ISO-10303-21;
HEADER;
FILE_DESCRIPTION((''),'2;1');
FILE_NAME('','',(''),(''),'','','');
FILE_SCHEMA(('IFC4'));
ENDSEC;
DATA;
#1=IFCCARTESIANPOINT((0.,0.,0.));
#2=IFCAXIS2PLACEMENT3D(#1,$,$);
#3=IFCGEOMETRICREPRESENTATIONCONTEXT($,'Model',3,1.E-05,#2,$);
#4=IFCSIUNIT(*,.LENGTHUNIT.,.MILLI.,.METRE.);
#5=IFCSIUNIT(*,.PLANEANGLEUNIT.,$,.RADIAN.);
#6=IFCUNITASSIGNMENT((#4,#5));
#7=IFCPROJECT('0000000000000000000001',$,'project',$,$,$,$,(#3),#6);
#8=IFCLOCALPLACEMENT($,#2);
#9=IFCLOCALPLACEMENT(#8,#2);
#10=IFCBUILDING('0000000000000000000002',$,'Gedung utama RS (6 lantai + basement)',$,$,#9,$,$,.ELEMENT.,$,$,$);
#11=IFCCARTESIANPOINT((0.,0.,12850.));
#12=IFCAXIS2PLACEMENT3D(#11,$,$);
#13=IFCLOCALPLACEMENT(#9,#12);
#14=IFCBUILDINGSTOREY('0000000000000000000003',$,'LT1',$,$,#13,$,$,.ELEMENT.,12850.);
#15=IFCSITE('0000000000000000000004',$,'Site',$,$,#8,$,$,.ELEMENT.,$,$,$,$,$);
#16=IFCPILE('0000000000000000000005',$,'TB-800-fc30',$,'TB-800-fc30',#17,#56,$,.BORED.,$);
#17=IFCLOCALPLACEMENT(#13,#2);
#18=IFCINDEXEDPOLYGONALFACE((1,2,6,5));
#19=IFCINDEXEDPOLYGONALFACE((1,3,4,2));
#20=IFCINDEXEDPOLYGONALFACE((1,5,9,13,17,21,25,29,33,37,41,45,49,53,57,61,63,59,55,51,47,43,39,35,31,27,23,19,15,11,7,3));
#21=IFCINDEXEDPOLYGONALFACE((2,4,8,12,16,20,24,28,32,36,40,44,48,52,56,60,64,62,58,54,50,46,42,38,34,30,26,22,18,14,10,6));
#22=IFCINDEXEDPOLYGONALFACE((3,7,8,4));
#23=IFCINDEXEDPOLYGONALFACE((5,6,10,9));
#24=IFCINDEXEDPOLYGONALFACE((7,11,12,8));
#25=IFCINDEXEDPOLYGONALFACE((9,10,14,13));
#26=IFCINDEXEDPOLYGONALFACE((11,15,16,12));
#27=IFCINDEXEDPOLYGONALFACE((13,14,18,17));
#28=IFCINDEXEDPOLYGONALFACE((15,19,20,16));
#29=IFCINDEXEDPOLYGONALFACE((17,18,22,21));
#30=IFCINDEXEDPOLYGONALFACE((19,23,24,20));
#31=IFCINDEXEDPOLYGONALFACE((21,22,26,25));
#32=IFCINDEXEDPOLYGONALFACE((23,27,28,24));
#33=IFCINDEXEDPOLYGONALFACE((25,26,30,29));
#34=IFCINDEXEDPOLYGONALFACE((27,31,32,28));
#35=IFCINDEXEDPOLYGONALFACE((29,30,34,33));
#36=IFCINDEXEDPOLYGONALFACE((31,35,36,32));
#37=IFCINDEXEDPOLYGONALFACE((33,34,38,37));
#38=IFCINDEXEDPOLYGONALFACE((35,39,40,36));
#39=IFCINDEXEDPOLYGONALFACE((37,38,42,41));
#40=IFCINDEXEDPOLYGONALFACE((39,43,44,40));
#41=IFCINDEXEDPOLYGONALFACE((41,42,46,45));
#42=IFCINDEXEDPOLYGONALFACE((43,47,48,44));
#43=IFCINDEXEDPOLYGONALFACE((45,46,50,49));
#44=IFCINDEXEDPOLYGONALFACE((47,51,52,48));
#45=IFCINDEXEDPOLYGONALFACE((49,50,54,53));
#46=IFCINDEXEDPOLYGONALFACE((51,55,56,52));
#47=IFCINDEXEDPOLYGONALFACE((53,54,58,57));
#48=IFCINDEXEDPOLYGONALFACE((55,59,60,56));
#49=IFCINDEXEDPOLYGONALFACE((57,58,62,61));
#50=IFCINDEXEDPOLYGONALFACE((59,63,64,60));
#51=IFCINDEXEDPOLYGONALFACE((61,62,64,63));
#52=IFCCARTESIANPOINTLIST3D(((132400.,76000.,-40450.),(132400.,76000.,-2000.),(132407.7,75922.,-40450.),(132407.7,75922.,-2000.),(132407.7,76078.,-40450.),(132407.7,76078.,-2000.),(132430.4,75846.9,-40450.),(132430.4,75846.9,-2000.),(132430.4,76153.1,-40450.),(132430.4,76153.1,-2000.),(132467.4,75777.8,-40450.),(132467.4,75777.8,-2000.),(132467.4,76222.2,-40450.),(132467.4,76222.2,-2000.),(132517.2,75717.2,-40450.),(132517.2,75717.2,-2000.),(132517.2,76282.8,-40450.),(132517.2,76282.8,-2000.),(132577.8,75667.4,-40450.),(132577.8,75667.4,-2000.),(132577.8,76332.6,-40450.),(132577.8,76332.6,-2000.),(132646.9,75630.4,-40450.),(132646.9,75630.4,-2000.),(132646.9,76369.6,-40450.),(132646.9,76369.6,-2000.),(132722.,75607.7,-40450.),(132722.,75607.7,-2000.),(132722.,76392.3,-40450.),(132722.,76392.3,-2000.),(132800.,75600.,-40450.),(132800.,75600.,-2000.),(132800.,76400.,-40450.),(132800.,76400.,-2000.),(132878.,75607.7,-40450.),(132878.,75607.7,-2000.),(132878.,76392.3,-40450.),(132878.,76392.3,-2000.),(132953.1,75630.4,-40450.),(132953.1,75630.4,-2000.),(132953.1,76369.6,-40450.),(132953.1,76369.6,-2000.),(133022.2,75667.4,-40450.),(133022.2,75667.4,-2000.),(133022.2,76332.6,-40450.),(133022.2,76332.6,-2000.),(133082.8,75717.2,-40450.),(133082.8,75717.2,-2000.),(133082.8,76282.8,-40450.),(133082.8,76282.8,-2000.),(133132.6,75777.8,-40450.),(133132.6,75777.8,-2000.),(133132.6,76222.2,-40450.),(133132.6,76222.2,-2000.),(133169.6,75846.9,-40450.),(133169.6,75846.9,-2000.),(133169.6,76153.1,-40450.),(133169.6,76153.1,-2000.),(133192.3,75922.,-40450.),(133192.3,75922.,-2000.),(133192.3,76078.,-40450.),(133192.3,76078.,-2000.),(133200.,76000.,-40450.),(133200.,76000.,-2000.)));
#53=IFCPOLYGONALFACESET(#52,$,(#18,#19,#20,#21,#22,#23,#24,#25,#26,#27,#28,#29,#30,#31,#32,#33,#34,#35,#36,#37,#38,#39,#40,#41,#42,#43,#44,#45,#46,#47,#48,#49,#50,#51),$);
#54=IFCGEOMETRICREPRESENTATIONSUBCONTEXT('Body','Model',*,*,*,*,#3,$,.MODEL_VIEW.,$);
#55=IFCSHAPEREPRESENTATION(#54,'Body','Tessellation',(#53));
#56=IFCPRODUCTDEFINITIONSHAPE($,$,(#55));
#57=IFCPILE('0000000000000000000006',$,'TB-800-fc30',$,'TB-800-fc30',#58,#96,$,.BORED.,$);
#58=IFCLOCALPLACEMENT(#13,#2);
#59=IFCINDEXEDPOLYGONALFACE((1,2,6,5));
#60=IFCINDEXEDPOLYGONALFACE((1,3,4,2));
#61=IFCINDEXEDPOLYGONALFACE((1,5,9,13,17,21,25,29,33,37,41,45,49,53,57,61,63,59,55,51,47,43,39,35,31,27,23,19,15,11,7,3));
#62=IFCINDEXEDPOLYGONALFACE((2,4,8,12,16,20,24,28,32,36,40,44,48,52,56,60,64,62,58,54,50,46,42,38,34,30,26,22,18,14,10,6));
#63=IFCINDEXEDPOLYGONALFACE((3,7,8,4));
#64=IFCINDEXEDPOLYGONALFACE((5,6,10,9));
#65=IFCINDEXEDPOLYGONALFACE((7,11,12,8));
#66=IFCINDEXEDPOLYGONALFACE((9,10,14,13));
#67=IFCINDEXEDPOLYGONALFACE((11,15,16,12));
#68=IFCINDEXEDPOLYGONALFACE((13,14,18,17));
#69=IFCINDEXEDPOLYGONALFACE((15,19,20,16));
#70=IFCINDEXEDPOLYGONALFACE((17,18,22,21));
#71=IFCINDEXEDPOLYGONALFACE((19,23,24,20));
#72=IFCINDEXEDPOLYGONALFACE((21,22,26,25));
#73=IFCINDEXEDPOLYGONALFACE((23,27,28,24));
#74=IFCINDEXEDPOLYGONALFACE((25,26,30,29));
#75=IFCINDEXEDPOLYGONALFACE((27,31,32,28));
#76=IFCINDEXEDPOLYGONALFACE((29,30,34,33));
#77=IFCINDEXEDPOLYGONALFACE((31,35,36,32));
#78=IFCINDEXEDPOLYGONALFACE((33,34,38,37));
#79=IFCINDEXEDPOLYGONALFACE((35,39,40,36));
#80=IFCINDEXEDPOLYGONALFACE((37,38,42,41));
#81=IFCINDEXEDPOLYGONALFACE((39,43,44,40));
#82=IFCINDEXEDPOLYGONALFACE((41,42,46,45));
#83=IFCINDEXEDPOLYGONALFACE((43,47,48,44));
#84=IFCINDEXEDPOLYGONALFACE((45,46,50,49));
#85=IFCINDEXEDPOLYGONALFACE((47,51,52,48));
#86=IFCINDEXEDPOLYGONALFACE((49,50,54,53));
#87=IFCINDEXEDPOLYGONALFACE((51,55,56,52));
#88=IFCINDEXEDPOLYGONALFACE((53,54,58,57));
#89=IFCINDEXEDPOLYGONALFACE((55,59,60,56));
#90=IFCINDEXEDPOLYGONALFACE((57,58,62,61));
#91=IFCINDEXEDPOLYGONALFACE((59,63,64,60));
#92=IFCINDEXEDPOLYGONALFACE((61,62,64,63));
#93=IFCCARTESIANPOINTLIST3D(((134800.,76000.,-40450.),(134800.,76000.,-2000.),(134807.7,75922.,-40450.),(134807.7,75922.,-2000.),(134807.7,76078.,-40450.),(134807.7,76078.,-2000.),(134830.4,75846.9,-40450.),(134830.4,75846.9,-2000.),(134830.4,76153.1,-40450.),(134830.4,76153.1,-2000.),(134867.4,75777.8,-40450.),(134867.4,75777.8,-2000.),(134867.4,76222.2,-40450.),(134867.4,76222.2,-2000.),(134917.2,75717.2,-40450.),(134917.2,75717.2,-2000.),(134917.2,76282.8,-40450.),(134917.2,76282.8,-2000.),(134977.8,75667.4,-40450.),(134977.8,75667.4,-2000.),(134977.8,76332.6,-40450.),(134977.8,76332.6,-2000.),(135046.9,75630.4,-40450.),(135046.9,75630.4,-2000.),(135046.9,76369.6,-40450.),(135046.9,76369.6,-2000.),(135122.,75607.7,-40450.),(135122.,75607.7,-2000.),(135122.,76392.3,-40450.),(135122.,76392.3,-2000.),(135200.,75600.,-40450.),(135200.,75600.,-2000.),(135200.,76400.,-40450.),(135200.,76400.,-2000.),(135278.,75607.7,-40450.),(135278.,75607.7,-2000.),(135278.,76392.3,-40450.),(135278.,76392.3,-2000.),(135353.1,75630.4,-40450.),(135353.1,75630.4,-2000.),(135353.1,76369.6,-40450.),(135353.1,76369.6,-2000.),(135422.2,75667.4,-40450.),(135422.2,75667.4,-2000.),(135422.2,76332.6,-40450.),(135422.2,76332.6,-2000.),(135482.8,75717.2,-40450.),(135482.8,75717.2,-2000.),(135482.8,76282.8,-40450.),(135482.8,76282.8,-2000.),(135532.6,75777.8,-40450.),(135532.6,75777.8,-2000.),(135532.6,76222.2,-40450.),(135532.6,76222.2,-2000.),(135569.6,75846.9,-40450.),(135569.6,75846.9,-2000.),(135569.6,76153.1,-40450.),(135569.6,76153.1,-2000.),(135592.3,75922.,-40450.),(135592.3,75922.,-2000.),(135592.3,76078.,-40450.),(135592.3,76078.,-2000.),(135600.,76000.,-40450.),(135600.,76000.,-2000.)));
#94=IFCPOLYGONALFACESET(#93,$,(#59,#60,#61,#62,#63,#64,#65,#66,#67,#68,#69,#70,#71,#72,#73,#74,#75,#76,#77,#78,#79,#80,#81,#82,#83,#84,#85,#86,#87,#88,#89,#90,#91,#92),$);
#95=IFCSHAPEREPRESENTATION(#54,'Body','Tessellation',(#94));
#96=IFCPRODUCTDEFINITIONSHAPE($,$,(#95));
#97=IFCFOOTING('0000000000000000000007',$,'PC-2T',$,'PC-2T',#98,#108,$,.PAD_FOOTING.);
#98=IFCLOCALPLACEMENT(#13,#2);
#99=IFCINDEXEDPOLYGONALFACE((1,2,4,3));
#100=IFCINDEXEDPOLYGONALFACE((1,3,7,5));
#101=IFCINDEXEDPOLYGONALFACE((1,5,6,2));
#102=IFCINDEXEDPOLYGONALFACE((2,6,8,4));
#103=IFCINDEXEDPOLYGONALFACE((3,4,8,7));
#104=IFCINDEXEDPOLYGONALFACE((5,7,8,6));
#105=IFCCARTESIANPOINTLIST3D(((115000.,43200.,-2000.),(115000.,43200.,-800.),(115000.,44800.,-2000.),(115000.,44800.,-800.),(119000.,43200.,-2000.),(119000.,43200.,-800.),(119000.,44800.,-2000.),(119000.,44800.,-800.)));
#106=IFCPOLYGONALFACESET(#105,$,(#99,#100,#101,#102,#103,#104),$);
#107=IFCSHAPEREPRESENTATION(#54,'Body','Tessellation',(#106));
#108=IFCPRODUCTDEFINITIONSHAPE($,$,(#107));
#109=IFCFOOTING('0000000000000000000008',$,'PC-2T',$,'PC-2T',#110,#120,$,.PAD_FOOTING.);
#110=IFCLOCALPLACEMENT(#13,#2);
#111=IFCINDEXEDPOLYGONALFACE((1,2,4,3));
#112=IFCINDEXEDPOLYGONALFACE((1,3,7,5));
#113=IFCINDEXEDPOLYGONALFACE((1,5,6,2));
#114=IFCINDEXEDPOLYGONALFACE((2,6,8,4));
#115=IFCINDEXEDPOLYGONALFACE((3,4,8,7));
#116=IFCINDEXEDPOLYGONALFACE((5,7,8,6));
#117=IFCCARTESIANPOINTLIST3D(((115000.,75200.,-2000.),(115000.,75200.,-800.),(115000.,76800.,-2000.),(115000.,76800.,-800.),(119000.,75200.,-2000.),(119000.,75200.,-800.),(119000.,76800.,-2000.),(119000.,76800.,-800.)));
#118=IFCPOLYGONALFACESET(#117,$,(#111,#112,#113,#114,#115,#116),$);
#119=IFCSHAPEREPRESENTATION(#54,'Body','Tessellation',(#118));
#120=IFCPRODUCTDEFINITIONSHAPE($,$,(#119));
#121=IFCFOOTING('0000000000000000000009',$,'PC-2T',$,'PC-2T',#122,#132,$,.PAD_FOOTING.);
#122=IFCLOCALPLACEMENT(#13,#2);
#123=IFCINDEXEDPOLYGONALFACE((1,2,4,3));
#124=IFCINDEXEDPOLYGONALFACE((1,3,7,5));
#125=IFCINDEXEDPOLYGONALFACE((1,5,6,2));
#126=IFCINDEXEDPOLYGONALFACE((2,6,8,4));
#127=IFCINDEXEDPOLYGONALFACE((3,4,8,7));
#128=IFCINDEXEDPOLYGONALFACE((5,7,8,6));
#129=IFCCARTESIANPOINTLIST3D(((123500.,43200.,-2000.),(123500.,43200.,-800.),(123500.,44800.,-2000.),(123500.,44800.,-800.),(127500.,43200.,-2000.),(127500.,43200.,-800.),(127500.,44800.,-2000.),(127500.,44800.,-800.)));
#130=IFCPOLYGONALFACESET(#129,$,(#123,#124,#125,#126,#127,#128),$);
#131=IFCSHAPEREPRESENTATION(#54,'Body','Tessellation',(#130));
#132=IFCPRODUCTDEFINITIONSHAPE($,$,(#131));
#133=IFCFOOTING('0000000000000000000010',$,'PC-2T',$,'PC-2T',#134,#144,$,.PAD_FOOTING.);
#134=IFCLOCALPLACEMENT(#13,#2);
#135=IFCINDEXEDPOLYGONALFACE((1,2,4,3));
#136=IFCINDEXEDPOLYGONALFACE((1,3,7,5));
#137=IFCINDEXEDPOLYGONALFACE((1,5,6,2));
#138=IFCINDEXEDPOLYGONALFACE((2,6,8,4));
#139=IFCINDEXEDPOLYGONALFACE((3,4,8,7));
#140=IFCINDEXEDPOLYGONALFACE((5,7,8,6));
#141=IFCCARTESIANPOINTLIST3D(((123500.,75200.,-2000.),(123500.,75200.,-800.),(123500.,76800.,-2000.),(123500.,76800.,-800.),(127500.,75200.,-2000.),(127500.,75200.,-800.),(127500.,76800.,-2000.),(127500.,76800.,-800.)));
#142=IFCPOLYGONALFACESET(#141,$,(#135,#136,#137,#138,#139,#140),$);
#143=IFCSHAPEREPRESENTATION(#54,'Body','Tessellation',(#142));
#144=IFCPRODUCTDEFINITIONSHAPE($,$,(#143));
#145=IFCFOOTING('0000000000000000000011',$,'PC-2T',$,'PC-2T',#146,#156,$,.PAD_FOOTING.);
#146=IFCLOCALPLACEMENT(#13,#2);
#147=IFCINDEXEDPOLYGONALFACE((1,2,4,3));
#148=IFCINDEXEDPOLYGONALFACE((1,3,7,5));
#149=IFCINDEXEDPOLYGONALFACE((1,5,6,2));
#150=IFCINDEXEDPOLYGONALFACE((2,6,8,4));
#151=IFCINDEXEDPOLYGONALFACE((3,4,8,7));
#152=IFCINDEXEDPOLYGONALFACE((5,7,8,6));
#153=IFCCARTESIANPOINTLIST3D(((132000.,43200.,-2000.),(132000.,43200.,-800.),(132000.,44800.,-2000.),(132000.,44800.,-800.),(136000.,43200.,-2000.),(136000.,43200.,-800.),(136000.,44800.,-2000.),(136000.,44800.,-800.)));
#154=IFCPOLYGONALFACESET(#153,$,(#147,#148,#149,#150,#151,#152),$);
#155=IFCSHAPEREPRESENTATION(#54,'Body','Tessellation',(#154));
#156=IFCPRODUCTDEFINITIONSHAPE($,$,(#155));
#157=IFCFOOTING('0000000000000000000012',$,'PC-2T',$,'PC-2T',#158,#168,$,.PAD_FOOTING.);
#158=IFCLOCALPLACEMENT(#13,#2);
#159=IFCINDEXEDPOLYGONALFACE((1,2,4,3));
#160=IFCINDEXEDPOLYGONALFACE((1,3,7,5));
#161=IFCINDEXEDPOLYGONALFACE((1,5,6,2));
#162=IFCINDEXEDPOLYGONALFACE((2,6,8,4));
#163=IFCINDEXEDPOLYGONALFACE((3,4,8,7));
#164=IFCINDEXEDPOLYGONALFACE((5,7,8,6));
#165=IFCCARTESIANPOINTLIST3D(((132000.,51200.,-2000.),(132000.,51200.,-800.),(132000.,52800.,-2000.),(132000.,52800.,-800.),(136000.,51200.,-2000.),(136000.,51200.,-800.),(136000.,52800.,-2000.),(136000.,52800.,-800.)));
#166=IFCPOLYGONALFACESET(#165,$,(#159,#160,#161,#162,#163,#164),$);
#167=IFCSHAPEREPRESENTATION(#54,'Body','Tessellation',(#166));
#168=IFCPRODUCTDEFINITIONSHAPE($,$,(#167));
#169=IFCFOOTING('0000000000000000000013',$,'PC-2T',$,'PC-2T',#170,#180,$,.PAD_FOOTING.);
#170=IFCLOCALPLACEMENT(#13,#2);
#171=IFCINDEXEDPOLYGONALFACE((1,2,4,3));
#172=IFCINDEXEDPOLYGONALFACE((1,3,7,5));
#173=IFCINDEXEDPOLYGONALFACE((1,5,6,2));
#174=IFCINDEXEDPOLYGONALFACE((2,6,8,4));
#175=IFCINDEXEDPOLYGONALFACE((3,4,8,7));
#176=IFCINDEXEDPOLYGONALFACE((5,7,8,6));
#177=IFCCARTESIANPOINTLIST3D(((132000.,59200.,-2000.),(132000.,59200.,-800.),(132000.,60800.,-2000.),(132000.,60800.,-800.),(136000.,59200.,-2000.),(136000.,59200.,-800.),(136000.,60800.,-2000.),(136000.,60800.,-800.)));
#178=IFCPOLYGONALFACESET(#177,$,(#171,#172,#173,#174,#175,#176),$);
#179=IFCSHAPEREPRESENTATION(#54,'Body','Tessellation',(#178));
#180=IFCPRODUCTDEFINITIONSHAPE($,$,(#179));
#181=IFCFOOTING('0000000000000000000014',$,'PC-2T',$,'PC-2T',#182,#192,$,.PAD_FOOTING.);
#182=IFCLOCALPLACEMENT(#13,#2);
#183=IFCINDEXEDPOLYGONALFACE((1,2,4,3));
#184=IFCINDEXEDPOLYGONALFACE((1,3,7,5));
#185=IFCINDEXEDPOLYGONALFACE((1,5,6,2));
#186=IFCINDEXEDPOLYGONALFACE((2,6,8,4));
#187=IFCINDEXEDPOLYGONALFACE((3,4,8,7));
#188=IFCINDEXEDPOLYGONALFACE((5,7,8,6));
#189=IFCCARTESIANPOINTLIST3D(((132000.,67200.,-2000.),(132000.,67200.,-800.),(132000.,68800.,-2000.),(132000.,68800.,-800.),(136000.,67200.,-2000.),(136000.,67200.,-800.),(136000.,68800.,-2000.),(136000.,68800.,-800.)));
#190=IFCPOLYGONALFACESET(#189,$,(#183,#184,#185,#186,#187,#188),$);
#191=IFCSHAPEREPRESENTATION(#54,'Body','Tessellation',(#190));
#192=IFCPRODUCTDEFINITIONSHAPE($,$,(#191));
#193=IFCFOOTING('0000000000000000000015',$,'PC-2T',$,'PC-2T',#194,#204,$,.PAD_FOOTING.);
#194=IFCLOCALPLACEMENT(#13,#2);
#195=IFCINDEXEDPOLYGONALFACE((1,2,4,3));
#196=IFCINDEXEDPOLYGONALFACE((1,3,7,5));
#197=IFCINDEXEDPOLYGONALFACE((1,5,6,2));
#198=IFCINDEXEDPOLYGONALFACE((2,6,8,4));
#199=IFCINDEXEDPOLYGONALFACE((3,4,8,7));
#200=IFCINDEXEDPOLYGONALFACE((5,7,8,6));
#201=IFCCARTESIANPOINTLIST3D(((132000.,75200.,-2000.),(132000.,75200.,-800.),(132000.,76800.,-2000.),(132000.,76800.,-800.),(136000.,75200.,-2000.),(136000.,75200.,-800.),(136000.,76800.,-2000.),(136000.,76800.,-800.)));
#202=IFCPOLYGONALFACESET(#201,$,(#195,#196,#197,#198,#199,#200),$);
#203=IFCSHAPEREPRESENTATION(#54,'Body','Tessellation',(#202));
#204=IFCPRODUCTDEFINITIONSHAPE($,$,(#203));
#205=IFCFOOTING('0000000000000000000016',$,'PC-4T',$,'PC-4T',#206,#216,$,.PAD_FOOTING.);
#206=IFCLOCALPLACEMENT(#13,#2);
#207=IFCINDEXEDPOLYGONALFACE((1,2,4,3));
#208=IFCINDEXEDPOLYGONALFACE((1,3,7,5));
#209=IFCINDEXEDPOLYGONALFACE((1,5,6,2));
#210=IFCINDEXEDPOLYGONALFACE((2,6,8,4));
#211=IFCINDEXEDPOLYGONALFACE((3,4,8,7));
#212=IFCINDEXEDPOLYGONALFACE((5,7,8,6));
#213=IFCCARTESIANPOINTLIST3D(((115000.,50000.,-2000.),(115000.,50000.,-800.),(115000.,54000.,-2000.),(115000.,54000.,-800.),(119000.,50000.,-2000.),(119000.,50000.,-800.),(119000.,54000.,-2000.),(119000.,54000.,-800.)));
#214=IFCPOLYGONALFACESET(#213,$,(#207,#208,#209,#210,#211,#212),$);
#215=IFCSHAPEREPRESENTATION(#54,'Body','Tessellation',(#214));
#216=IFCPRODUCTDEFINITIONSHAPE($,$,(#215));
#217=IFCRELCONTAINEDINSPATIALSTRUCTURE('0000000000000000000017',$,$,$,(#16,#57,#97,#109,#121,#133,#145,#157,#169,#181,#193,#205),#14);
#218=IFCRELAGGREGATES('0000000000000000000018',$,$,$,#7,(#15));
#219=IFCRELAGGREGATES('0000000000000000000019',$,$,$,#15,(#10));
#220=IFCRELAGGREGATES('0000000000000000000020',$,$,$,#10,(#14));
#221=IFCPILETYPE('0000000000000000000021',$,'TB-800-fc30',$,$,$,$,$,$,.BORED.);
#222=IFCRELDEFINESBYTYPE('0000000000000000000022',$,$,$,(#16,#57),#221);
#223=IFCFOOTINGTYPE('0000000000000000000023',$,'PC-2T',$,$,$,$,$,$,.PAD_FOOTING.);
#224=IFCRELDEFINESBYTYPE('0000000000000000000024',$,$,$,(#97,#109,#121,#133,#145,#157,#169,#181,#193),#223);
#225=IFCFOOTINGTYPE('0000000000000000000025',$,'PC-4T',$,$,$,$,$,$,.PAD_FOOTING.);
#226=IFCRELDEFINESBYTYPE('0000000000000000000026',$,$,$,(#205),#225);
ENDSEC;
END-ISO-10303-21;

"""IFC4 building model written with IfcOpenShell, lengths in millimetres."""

from ifc_helpers import new_model, si_unit, frame, origin, origin_2d, place, context, subcontext, project, spatial, rectangle, circle, extrude, material_profile, profile_set, profile_usage, type_object, element, save


model = new_model("IFC4")

# Units and contexts
model_context = context("Model", 3, precision=1e-05, world=origin())
body_context = subcontext(model_context, "Body", "Model", "MODEL_VIEW")
ifc_project = project(units=[si_unit("LENGTHUNIT", "METRE", prefix="MILLI"), si_unit("PLANEANGLEUNIT", "RADIAN")], contexts=[model_context])

# Site, building, storey
site_placement = place(None, origin())
site = spatial("IfcSite", under=ifc_project, at=site_placement, Name="Site", CompositionType="ELEMENT")
building_placement = place(site_placement, origin())
building = spatial("IfcBuilding", under=site, at=building_placement, Name="Gedung utama RS (6 lantai + basement)", CompositionType="ELEMENT")
storey_placement = place(building_placement, frame((0.0, 0.0, 12850.0)))
storey = spatial("IfcBuildingStorey", under=building, at=storey_placement, Name="LT1", CompositionType="ELEMENT", Elevation=12850.0)

# Piles
ifc_material_profile_1 = material_profile(None, circle(Radius=400.0, at=origin_2d()), Name="TB-800-fc30")
ifc_profile_set_1 = profile_set([ifc_material_profile_1], Name="TB-800-fc30")
ifc_profile_usage_1 = profile_usage(ifc_profile_set_1, cardinal=5)
pile_type = type_object("IfcPileType", Name="TB-800-fc30", PredefinedType="BORED", material=ifc_profile_set_1)
for number, where, z_axis, x_axis, name in (
    (1, (132800.0, 76000.0, -40450.0), (0.0, 0.0, 1.0), (1.0, 0.0, 0.0), "TB-800-fc30"),
    (2, (135200.0, 76000.0, -40450.0), (0.0, 0.0, 1.0), (1.0, 0.0, 0.0), "TB-800-fc30"),
):
    element("IfcPile", number, at=place(storey_placement, frame(where, z_axis=z_axis, x_axis=x_axis)), inside=storey, type_object=pile_type, material=ifc_profile_usage_1, Name=name, ObjectType="TB-800-fc30", PredefinedType="BORED", context=body_context, shape_type="SweptSolid", body=[
        extrude(circle(Radius=400.0, at=origin_2d()), origin(), (0.0, 0.0, 1.0), 38450.0),
    ])

# Footings
ifc_material_profile_2 = material_profile(None, rectangle(XDim=4000.0, YDim=1600.0, at=origin_2d()), Name="PC-2T")
ifc_profile_set_2 = profile_set([ifc_material_profile_2], Name="PC-2T")
ifc_profile_usage_2 = profile_usage(ifc_profile_set_2, cardinal=5)
footing_type_1 = type_object("IfcFootingType", Name="PC-2T", PredefinedType="PAD_FOOTING", material=ifc_profile_set_2)
for number, where, z_axis, x_axis, name in (
    (3, (117000.0, 44000.0, -2000.0), (0.0, 0.0, 1.0), (1.0, 0.0, 0.0), "PC-2T"),
    (4, (117000.0, 76000.0, -2000.0), (0.0, 0.0, 1.0), (1.0, 0.0, 0.0), "PC-2T"),
    (5, (125500.0, 44000.0, -2000.0), (0.0, 0.0, 1.0), (1.0, 0.0, 0.0), "PC-2T"),
    (6, (125500.0, 76000.0, -2000.0), (0.0, 0.0, 1.0), (1.0, 0.0, 0.0), "PC-2T"),
    (7, (134000.0, 44000.0, -2000.0), (0.0, 0.0, 1.0), (1.0, 0.0, 0.0), "PC-2T"),
    (8, (134000.0, 52000.0, -2000.0), (0.0, 0.0, 1.0), (1.0, 0.0, 0.0), "PC-2T"),
    (9, (134000.0, 60000.0, -2000.0), (0.0, 0.0, 1.0), (1.0, 0.0, 0.0), "PC-2T"),
    (10, (134000.0, 68000.0, -2000.0), (0.0, 0.0, 1.0), (1.0, 0.0, 0.0), "PC-2T"),
    (11, (134000.0, 76000.0, -2000.0), (0.0, 0.0, 1.0), (1.0, 0.0, 0.0), "PC-2T"),
):
    element("IfcFooting", number, at=place(storey_placement, frame(where, z_axis=z_axis, x_axis=x_axis)), inside=storey, type_object=footing_type_1, material=ifc_profile_usage_2, Name=name, ObjectType="PC-2T", PredefinedType="PAD_FOOTING", context=body_context, shape_type="SweptSolid", body=[
        extrude(rectangle(XDim=4000.0, YDim=1600.0, at=origin_2d()), origin(), (0.0, 0.0, 1.0), 1200.0),
    ])
ifc_material_profile_3 = material_profile(None, rectangle(XDim=4000.0, YDim=4000.0, at=origin_2d()), Name="PC-4T")
ifc_profile_set_3 = profile_set([ifc_material_profile_3], Name="PC-4T")
ifc_profile_usage_3 = profile_usage(ifc_profile_set_3, cardinal=5)
footing_type_2 = type_object("IfcFootingType", Name="PC-4T", PredefinedType="PAD_FOOTING", material=ifc_profile_set_3)
for number, where, z_axis, x_axis, name in (
    (12, (117000.0, 52000.0, -2000.0), (0.0, 0.0, 1.0), (1.0, 0.0, 0.0), "PC-4T"),
):
    element("IfcFooting", number, at=place(storey_placement, frame(where, z_axis=z_axis, x_axis=x_axis)), inside=storey, type_object=footing_type_2, material=ifc_profile_usage_3, Name=name, ObjectType="PC-4T", PredefinedType="PAD_FOOTING", context=body_context, shape_type="SweptSolid", body=[
        extrude(rectangle(XDim=4000.0, YDim=4000.0, at=origin_2d()), origin(), (0.0, 0.0, 1.0), 1200.0),
    ])

save(model, "model.ifc")
